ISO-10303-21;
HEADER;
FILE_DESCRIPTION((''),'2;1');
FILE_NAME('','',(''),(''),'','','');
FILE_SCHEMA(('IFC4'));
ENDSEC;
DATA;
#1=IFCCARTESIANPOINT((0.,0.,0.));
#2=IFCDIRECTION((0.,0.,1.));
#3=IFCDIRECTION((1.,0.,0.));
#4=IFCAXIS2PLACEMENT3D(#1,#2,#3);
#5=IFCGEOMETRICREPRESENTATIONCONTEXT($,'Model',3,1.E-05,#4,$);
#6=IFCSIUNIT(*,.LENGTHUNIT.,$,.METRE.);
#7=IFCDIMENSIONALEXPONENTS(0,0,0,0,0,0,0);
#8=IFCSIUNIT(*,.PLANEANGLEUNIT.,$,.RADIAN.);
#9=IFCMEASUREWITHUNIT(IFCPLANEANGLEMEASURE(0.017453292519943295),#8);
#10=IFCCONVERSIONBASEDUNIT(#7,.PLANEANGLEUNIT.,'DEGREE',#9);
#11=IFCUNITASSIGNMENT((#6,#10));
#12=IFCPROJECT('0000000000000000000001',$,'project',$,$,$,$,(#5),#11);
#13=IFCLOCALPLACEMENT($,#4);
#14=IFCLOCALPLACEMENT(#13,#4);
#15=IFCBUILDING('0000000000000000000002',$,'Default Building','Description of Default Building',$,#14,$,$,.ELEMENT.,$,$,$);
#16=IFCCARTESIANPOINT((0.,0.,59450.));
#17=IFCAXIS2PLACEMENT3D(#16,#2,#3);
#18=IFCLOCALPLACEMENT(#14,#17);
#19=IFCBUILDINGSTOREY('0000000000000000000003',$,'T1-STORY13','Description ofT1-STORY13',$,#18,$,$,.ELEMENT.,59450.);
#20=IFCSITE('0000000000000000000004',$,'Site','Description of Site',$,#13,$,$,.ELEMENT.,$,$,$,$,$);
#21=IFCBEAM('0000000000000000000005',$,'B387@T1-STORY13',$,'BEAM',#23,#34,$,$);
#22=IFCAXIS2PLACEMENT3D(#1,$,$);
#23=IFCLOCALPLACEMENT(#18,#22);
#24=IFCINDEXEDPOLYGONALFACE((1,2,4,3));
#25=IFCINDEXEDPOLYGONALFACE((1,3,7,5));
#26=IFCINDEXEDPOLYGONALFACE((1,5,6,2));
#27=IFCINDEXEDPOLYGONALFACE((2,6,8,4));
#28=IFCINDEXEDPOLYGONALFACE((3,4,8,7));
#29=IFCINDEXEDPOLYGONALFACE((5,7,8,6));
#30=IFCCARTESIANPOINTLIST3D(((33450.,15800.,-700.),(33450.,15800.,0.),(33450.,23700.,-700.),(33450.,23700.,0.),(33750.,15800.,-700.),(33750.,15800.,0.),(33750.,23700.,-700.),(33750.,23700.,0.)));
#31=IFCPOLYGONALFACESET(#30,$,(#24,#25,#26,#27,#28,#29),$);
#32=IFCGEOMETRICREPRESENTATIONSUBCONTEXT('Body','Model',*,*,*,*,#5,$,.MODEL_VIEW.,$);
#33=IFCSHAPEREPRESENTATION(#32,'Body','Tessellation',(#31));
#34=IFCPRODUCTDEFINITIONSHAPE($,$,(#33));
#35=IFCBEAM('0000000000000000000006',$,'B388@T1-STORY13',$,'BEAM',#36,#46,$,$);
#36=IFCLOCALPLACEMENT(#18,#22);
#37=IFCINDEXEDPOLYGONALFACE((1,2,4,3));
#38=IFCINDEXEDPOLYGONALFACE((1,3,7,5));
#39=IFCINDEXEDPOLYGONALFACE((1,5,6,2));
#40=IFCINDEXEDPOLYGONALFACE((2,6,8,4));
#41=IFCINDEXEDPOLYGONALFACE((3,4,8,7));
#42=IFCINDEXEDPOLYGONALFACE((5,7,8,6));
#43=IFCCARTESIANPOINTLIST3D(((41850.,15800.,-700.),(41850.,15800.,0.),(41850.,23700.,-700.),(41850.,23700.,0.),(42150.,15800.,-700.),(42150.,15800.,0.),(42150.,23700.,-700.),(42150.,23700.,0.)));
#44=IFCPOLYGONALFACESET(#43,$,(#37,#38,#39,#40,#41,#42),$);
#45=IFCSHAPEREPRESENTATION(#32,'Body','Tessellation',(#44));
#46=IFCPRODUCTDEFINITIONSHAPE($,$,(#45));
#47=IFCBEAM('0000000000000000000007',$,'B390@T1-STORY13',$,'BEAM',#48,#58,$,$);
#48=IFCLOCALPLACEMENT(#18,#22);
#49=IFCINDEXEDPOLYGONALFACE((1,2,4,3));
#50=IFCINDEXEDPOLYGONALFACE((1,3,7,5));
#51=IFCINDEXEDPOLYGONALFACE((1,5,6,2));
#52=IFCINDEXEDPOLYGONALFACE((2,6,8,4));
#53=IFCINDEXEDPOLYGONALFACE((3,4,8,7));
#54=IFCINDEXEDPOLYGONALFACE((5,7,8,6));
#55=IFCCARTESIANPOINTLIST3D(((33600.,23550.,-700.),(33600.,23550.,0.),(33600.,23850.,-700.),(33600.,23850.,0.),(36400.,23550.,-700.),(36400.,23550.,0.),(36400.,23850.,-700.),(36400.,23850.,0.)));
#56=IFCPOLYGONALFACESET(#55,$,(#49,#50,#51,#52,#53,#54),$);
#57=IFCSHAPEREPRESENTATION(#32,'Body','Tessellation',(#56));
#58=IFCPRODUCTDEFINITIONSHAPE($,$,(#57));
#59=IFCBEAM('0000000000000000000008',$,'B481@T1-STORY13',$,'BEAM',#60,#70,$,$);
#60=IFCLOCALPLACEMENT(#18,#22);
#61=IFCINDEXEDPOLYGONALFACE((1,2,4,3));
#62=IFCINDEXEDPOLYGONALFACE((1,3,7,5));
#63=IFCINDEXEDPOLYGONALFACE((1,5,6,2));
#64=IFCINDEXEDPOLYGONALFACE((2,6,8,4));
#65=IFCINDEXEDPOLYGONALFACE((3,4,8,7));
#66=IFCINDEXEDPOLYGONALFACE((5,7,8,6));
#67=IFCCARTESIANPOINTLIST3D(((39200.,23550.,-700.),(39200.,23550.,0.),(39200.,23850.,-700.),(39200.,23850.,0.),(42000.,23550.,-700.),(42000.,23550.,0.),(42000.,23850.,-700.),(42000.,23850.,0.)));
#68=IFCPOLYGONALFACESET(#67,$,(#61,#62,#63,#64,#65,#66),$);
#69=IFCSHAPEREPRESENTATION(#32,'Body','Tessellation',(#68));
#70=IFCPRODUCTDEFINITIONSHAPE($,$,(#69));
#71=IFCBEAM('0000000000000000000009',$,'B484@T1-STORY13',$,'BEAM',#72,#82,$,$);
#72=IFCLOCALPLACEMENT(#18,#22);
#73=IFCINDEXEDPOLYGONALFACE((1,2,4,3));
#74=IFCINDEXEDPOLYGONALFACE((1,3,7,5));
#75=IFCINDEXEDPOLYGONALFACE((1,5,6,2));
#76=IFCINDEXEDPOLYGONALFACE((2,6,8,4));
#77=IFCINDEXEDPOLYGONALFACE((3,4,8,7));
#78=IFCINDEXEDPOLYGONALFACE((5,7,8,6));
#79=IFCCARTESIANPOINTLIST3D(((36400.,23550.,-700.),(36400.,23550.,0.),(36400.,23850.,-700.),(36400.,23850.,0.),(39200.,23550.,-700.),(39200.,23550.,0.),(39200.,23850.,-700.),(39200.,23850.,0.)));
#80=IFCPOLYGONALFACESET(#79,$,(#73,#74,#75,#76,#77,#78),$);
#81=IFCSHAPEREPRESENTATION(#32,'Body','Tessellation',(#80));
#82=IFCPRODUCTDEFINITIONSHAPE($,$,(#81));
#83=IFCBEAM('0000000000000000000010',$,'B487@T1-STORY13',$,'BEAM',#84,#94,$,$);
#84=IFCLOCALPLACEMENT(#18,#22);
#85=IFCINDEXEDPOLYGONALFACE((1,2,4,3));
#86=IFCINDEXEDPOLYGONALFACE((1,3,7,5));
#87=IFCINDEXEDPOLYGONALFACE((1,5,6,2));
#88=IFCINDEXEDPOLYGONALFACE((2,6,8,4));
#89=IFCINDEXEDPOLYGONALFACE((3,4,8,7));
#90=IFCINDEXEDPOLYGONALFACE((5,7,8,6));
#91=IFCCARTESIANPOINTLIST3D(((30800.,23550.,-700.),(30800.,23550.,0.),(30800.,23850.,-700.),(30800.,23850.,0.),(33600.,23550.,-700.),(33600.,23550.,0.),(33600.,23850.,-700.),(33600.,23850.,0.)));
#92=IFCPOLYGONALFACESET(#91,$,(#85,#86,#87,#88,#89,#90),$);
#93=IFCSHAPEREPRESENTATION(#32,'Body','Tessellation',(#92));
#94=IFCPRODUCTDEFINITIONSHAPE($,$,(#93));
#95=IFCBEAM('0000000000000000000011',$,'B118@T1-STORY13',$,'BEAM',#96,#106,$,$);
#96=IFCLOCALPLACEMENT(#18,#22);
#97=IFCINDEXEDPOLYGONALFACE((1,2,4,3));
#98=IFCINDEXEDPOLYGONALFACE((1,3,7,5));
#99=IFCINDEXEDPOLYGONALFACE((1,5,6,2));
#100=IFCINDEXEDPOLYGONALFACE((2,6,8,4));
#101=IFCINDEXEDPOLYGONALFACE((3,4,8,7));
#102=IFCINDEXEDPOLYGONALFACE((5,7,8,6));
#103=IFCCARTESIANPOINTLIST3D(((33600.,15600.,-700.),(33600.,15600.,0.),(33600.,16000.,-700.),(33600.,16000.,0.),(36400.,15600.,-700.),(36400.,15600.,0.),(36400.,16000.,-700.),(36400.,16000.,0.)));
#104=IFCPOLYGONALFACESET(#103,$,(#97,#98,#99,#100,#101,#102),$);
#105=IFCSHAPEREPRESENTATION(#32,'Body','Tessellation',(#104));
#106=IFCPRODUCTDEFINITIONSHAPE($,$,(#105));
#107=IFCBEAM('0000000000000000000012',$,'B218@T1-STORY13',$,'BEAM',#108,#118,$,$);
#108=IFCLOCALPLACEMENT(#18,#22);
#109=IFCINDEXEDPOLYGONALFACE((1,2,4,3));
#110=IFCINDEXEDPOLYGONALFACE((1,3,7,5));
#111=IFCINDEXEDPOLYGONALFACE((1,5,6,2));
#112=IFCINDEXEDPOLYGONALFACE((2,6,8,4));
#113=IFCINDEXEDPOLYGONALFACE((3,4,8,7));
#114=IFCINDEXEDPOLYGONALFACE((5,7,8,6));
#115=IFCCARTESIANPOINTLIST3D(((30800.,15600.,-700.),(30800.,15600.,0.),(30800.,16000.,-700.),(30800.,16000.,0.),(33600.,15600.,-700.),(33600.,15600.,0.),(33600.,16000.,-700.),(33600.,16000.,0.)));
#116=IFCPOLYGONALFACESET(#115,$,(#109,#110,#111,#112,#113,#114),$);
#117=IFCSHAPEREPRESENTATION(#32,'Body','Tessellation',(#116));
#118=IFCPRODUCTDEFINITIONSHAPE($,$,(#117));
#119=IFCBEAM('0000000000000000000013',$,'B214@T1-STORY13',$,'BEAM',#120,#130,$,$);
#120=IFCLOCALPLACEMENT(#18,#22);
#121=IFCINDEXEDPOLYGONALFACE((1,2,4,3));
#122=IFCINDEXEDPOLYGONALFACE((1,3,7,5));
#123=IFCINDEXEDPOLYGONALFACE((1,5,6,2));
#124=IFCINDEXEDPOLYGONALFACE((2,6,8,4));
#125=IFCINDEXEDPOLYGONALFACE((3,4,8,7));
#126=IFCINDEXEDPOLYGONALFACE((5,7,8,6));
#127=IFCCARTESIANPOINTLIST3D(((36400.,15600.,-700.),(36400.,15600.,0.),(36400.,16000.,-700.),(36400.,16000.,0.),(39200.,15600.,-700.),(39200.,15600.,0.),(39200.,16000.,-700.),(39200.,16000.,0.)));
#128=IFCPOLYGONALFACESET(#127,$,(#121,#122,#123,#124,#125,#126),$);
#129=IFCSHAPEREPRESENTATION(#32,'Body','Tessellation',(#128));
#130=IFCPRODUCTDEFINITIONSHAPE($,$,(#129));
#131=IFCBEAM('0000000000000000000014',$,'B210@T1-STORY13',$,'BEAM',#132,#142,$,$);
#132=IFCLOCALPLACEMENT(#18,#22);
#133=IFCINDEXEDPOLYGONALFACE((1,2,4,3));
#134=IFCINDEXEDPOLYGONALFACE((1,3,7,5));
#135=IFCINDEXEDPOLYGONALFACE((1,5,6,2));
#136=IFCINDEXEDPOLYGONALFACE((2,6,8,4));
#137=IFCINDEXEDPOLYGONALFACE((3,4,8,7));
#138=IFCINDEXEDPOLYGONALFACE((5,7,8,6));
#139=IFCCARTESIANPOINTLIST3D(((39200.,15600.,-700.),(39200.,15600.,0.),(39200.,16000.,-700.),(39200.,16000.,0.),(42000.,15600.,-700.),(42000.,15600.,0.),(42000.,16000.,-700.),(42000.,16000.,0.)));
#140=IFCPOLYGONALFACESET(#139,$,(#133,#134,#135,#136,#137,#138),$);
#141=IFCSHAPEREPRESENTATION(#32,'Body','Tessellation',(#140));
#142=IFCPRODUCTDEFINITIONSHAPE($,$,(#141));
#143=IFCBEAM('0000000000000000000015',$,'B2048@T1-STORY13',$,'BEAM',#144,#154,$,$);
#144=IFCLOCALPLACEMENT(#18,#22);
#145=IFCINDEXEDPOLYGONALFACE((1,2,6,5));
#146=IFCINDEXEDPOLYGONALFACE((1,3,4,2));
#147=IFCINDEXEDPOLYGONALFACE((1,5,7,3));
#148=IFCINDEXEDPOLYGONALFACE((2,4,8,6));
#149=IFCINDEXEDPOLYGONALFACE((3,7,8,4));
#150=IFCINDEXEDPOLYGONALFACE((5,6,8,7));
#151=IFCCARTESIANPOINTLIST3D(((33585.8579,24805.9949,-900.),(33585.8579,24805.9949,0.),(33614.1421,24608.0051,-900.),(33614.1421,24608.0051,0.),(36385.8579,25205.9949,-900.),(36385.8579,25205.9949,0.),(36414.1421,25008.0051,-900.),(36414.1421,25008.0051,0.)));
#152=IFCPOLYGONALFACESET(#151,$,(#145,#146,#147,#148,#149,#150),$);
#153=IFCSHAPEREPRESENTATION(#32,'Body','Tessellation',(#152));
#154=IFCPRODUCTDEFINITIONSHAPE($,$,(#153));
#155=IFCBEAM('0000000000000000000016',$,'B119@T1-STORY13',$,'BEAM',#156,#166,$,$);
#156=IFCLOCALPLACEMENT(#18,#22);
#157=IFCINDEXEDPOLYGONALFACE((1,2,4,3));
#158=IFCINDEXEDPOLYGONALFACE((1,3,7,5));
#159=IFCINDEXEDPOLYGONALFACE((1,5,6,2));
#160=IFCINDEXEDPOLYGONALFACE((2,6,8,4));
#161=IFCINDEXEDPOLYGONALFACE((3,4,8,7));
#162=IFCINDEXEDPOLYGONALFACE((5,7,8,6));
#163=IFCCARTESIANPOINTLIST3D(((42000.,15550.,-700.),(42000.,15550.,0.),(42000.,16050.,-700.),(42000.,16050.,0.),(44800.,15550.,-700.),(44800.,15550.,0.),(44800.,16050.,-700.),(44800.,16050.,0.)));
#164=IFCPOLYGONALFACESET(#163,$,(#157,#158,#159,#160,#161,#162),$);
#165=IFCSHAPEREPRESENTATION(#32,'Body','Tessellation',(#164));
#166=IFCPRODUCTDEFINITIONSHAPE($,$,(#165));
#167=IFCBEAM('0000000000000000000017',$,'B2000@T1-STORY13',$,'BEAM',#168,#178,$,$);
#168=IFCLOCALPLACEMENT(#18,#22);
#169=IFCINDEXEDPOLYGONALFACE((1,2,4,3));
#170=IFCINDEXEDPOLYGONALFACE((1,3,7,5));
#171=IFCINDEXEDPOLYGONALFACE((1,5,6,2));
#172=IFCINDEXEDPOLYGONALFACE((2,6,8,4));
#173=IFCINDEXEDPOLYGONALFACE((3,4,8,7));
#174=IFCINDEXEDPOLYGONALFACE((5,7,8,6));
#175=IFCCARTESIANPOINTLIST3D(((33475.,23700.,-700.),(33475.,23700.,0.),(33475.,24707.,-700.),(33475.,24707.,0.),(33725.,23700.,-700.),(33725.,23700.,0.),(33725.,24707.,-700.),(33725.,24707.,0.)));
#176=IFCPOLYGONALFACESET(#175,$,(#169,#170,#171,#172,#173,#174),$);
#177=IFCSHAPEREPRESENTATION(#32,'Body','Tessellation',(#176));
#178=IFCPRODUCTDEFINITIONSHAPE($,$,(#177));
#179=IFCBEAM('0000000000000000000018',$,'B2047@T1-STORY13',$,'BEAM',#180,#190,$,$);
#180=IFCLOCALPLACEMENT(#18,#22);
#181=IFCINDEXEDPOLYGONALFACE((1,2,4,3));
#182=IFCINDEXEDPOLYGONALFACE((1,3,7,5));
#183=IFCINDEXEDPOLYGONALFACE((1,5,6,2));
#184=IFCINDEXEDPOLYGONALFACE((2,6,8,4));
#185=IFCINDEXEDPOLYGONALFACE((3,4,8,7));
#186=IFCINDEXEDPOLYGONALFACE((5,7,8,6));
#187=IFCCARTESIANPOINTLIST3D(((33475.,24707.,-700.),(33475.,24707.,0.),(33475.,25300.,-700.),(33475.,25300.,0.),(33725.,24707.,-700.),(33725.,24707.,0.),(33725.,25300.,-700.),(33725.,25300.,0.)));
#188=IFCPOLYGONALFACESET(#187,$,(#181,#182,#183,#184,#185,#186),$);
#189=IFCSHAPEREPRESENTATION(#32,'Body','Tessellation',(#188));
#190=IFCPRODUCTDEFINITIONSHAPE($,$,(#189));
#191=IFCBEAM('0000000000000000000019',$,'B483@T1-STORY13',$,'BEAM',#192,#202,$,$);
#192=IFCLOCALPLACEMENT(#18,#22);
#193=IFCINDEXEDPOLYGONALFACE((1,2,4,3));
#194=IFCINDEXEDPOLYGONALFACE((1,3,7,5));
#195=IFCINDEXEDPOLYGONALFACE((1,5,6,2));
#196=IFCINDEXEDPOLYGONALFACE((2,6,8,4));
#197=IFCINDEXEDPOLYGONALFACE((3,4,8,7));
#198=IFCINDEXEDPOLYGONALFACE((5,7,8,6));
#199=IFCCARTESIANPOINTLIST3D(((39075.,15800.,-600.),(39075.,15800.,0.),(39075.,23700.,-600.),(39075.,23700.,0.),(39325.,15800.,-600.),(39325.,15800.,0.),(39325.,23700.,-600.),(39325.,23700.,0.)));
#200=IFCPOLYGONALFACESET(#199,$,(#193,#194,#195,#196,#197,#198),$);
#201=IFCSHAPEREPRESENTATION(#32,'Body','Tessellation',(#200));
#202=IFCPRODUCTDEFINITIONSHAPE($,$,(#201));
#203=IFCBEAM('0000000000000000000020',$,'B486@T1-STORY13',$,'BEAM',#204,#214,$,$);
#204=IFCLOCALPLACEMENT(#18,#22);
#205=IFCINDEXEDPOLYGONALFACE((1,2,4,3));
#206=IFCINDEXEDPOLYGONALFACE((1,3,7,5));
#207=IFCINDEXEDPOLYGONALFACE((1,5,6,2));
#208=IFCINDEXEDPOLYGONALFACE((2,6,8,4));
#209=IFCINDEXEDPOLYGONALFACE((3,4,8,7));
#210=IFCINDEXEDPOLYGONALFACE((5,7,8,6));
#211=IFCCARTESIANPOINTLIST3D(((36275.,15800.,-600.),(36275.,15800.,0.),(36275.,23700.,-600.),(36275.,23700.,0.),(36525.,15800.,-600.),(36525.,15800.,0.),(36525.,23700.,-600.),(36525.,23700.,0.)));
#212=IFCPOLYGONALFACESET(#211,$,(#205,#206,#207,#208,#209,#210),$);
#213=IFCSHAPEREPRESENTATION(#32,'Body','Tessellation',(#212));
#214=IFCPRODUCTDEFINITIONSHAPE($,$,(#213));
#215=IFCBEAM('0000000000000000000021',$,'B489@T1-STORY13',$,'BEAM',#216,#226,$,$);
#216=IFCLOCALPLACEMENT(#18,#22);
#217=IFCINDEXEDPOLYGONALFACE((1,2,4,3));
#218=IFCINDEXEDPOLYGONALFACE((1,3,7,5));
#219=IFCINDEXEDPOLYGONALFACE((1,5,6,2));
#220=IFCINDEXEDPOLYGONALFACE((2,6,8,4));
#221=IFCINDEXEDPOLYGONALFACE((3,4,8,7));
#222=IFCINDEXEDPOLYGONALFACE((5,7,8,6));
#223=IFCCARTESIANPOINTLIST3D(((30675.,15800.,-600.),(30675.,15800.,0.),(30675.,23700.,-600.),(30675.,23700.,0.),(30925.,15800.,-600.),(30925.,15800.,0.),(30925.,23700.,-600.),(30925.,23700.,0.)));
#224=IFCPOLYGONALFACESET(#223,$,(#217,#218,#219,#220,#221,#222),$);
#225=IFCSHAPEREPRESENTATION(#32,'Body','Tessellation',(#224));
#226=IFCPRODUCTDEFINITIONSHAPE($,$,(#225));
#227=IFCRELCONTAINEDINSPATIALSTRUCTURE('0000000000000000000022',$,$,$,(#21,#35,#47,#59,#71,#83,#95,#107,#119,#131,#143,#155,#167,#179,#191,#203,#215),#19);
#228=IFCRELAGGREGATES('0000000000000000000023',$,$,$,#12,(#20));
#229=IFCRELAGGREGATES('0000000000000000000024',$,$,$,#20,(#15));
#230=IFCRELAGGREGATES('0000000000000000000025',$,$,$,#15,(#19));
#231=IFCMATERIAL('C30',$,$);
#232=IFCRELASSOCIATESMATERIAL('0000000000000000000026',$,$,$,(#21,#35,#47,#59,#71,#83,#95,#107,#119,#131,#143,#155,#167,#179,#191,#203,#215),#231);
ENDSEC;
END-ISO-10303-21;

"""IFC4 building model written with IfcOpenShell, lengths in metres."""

from ifc_helpers import new_model, entity, si_unit, converted_unit, frame, origin_with_axes, place, context, subcontext, project, spatial, rectangle, extrude, material, element, save


model = new_model("IFC4")

# Units and contexts
model_context = context("Model", 3, precision=1e-05, world=origin_with_axes())
body_context = subcontext(model_context, "Body", "Model", "MODEL_VIEW")
ifc_project = project(units=[si_unit("LENGTHUNIT", "METRE"), converted_unit("PLANEANGLEUNIT", "DEGREE", entity("IfcPlaneAngleMeasure", 0.017453292519943295), si_unit("PLANEANGLEUNIT", "RADIAN"), dimensions=[0, 0, 0, 0, 0, 0, 0])], contexts=[model_context])

# Site, building, storey
site_placement = place(None, origin_with_axes())
site = spatial("IfcSite", under=ifc_project, at=site_placement, Name="Site", Description="Description of Site", CompositionType="ELEMENT")
building_placement = place(site_placement, origin_with_axes())
building = spatial("IfcBuilding", under=site, at=building_placement, Name="Default Building", Description="Description of Default Building", CompositionType="ELEMENT")
storey_placement = place(building_placement, frame((0.0, 0.0, 59450.0), z_axis=(0.0, 0.0, 1.0), x_axis=(1.0, 0.0, 0.0)))
storey = spatial("IfcBuildingStorey", under=building, at=storey_placement, Name="T1-STORY13", Description="Description ofT1-STORY13", CompositionType="ELEMENT", Elevation=59450.0)

# Beams
ifc_material_1 = material(Name="C30")
for number, where, z_axis, x_axis, name in (
    (1, (33600.0, 15800.0, -350.0), (0.0, 1.0, 0.0), (-1.0, 0.0, 0.0), "B387@T1-STORY13"),
    (2, (42000.0, 15800.0, -350.0), (0.0, 1.0, 0.0), (-1.0, 0.0, 0.0), "B388@T1-STORY13"),
):
    element("IfcBeam", number, at=place(storey_placement, frame(where, z_axis=z_axis, x_axis=x_axis)), inside=storey, material=ifc_material_1, Name=name, ObjectType="BEAM", context=body_context, shape_type="SweptSolid", body=[
        extrude(rectangle(XDim=300.0, YDim=700.0), origin_with_axes(), (0.0, 0.0, 1.0), 7900.0),
    ])
for number, where, z_axis, x_axis, name in (
    (3, (33600.0, 23700.0, -350.0), (1.0, 0.0, 0.0), (0.0, 1.0, 0.0), "B390@T1-STORY13"),
    (4, (39200.0, 23700.0, -350.0), (1.0, 0.0, 0.0), (0.0, 1.0, 0.0), "B481@T1-STORY13"),
    (5, (36400.0, 23700.0, -350.0), (1.0, 0.0, 0.0), (0.0, 1.0, 0.0), "B484@T1-STORY13"),
    (6, (30800.0, 23700.0, -350.0), (1.0, 0.0, 0.0), (0.0, 1.0, 0.0), "B487@T1-STORY13"),
):
    element("IfcBeam", number, at=place(storey_placement, frame(where, z_axis=z_axis, x_axis=x_axis)), inside=storey, material=ifc_material_1, Name=name, ObjectType="BEAM", context=body_context, shape_type="SweptSolid", body=[
        extrude(rectangle(XDim=300.0, YDim=700.0), origin_with_axes(), (0.0, 0.0, 1.0), 2800.0),
    ])
for number, where, z_axis, x_axis, name in (
    (7, (33600.0, 15800.0, -350.0), (1.0, 0.0, 0.0), (0.0, 1.0, 0.0), "B118@T1-STORY13"),
    (8, (30800.0, 15800.0, -350.0), (1.0, 0.0, 0.0), (0.0, 1.0, 0.0), "B218@T1-STORY13"),
    (9, (36400.0, 15800.0, -350.0), (1.0, 0.0, 0.0), (0.0, 1.0, 0.0), "B214@T1-STORY13"),
    (10, (39200.0, 15800.0, -350.0), (1.0, 0.0, 0.0), (0.0, 1.0, 0.0), "B210@T1-STORY13"),
):
    element("IfcBeam", number, at=place(storey_placement, frame(where, z_axis=z_axis, x_axis=x_axis)), inside=storey, material=ifc_material_1, Name=name, ObjectType="BEAM", context=body_context, shape_type="SweptSolid", body=[
        extrude(rectangle(XDim=400.0, YDim=700.0), origin_with_axes(), (0.0, 0.0, 1.0), 2800.0),
    ])
beam_1_placement = place(storey_placement, frame((33600.0, 24707.0, -450.0), z_axis=(0.989949, 0.141421, 0.0), x_axis=(-0.141421, 0.989949, 0.0)))
element("IfcBeam", 11, at=beam_1_placement, inside=storey, material=ifc_material_1, Name="B2048@T1-STORY13", ObjectType="BEAM", context=body_context, shape_type="SweptSolid", body=[
    extrude(rectangle(XDim=200.0, YDim=900.0), origin_with_axes(), (0.0, 0.0, 1.0), 2828.4271),
])
beam_2_placement = place(storey_placement, frame((42000.0, 15800.0, -350.0), z_axis=(1.0, 0.0, 0.0), x_axis=(0.0, 1.0, 0.0)))
element("IfcBeam", 12, at=beam_2_placement, inside=storey, material=ifc_material_1, Name="B119@T1-STORY13", ObjectType="BEAM", context=body_context, shape_type="SweptSolid", body=[
    extrude(rectangle(XDim=500.0, YDim=700.0), origin_with_axes(), (0.0, 0.0, 1.0), 2800.0),
])
beam_3_placement = place(storey_placement, frame((33600.0, 23700.0, -350.0), z_axis=(0.0, 1.0, 0.0), x_axis=(-1.0, 0.0, 0.0)))
element("IfcBeam", 13, at=beam_3_placement, inside=storey, material=ifc_material_1, Name="B2000@T1-STORY13", ObjectType="BEAM", context=body_context, shape_type="SweptSolid", body=[
    extrude(rectangle(XDim=250.0, YDim=700.0), origin_with_axes(), (0.0, 0.0, 1.0), 1007.0),
])
beam_4_placement = place(storey_placement, frame((33600.0, 24707.0, -350.0), z_axis=(0.0, 1.0, 0.0), x_axis=(-1.0, 0.0, 0.0)))
element("IfcBeam", 14, at=beam_4_placement, inside=storey, material=ifc_material_1, Name="B2047@T1-STORY13", ObjectType="BEAM", context=body_context, shape_type="SweptSolid", body=[
    extrude(rectangle(XDim=250.0, YDim=700.0), origin_with_axes(), (0.0, 0.0, 1.0), 593.0),
])
for number, where, z_axis, x_axis, name in (
    (15, (39200.0, 15800.0, -300.0), (0.0, 1.0, 0.0), (-1.0, 0.0, 0.0), "B483@T1-STORY13"),
    (16, (36400.0, 15800.0, -300.0), (0.0, 1.0, 0.0), (-1.0, 0.0, 0.0), "B486@T1-STORY13"),
    (17, (30800.0, 15800.0, -300.0), (0.0, 1.0, 0.0), (-1.0, 0.0, 0.0), "B489@T1-STORY13"),
):
    element("IfcBeam", number, at=place(storey_placement, frame(where, z_axis=z_axis, x_axis=x_axis)), inside=storey, material=ifc_material_1, Name=name, ObjectType="BEAM", context=body_context, shape_type="SweptSolid", body=[
        extrude(rectangle(XDim=250.0, YDim=600.0), origin_with_axes(), (0.0, 0.0, 1.0), 7900.0),
    ])

save(model, "model.ifc")
